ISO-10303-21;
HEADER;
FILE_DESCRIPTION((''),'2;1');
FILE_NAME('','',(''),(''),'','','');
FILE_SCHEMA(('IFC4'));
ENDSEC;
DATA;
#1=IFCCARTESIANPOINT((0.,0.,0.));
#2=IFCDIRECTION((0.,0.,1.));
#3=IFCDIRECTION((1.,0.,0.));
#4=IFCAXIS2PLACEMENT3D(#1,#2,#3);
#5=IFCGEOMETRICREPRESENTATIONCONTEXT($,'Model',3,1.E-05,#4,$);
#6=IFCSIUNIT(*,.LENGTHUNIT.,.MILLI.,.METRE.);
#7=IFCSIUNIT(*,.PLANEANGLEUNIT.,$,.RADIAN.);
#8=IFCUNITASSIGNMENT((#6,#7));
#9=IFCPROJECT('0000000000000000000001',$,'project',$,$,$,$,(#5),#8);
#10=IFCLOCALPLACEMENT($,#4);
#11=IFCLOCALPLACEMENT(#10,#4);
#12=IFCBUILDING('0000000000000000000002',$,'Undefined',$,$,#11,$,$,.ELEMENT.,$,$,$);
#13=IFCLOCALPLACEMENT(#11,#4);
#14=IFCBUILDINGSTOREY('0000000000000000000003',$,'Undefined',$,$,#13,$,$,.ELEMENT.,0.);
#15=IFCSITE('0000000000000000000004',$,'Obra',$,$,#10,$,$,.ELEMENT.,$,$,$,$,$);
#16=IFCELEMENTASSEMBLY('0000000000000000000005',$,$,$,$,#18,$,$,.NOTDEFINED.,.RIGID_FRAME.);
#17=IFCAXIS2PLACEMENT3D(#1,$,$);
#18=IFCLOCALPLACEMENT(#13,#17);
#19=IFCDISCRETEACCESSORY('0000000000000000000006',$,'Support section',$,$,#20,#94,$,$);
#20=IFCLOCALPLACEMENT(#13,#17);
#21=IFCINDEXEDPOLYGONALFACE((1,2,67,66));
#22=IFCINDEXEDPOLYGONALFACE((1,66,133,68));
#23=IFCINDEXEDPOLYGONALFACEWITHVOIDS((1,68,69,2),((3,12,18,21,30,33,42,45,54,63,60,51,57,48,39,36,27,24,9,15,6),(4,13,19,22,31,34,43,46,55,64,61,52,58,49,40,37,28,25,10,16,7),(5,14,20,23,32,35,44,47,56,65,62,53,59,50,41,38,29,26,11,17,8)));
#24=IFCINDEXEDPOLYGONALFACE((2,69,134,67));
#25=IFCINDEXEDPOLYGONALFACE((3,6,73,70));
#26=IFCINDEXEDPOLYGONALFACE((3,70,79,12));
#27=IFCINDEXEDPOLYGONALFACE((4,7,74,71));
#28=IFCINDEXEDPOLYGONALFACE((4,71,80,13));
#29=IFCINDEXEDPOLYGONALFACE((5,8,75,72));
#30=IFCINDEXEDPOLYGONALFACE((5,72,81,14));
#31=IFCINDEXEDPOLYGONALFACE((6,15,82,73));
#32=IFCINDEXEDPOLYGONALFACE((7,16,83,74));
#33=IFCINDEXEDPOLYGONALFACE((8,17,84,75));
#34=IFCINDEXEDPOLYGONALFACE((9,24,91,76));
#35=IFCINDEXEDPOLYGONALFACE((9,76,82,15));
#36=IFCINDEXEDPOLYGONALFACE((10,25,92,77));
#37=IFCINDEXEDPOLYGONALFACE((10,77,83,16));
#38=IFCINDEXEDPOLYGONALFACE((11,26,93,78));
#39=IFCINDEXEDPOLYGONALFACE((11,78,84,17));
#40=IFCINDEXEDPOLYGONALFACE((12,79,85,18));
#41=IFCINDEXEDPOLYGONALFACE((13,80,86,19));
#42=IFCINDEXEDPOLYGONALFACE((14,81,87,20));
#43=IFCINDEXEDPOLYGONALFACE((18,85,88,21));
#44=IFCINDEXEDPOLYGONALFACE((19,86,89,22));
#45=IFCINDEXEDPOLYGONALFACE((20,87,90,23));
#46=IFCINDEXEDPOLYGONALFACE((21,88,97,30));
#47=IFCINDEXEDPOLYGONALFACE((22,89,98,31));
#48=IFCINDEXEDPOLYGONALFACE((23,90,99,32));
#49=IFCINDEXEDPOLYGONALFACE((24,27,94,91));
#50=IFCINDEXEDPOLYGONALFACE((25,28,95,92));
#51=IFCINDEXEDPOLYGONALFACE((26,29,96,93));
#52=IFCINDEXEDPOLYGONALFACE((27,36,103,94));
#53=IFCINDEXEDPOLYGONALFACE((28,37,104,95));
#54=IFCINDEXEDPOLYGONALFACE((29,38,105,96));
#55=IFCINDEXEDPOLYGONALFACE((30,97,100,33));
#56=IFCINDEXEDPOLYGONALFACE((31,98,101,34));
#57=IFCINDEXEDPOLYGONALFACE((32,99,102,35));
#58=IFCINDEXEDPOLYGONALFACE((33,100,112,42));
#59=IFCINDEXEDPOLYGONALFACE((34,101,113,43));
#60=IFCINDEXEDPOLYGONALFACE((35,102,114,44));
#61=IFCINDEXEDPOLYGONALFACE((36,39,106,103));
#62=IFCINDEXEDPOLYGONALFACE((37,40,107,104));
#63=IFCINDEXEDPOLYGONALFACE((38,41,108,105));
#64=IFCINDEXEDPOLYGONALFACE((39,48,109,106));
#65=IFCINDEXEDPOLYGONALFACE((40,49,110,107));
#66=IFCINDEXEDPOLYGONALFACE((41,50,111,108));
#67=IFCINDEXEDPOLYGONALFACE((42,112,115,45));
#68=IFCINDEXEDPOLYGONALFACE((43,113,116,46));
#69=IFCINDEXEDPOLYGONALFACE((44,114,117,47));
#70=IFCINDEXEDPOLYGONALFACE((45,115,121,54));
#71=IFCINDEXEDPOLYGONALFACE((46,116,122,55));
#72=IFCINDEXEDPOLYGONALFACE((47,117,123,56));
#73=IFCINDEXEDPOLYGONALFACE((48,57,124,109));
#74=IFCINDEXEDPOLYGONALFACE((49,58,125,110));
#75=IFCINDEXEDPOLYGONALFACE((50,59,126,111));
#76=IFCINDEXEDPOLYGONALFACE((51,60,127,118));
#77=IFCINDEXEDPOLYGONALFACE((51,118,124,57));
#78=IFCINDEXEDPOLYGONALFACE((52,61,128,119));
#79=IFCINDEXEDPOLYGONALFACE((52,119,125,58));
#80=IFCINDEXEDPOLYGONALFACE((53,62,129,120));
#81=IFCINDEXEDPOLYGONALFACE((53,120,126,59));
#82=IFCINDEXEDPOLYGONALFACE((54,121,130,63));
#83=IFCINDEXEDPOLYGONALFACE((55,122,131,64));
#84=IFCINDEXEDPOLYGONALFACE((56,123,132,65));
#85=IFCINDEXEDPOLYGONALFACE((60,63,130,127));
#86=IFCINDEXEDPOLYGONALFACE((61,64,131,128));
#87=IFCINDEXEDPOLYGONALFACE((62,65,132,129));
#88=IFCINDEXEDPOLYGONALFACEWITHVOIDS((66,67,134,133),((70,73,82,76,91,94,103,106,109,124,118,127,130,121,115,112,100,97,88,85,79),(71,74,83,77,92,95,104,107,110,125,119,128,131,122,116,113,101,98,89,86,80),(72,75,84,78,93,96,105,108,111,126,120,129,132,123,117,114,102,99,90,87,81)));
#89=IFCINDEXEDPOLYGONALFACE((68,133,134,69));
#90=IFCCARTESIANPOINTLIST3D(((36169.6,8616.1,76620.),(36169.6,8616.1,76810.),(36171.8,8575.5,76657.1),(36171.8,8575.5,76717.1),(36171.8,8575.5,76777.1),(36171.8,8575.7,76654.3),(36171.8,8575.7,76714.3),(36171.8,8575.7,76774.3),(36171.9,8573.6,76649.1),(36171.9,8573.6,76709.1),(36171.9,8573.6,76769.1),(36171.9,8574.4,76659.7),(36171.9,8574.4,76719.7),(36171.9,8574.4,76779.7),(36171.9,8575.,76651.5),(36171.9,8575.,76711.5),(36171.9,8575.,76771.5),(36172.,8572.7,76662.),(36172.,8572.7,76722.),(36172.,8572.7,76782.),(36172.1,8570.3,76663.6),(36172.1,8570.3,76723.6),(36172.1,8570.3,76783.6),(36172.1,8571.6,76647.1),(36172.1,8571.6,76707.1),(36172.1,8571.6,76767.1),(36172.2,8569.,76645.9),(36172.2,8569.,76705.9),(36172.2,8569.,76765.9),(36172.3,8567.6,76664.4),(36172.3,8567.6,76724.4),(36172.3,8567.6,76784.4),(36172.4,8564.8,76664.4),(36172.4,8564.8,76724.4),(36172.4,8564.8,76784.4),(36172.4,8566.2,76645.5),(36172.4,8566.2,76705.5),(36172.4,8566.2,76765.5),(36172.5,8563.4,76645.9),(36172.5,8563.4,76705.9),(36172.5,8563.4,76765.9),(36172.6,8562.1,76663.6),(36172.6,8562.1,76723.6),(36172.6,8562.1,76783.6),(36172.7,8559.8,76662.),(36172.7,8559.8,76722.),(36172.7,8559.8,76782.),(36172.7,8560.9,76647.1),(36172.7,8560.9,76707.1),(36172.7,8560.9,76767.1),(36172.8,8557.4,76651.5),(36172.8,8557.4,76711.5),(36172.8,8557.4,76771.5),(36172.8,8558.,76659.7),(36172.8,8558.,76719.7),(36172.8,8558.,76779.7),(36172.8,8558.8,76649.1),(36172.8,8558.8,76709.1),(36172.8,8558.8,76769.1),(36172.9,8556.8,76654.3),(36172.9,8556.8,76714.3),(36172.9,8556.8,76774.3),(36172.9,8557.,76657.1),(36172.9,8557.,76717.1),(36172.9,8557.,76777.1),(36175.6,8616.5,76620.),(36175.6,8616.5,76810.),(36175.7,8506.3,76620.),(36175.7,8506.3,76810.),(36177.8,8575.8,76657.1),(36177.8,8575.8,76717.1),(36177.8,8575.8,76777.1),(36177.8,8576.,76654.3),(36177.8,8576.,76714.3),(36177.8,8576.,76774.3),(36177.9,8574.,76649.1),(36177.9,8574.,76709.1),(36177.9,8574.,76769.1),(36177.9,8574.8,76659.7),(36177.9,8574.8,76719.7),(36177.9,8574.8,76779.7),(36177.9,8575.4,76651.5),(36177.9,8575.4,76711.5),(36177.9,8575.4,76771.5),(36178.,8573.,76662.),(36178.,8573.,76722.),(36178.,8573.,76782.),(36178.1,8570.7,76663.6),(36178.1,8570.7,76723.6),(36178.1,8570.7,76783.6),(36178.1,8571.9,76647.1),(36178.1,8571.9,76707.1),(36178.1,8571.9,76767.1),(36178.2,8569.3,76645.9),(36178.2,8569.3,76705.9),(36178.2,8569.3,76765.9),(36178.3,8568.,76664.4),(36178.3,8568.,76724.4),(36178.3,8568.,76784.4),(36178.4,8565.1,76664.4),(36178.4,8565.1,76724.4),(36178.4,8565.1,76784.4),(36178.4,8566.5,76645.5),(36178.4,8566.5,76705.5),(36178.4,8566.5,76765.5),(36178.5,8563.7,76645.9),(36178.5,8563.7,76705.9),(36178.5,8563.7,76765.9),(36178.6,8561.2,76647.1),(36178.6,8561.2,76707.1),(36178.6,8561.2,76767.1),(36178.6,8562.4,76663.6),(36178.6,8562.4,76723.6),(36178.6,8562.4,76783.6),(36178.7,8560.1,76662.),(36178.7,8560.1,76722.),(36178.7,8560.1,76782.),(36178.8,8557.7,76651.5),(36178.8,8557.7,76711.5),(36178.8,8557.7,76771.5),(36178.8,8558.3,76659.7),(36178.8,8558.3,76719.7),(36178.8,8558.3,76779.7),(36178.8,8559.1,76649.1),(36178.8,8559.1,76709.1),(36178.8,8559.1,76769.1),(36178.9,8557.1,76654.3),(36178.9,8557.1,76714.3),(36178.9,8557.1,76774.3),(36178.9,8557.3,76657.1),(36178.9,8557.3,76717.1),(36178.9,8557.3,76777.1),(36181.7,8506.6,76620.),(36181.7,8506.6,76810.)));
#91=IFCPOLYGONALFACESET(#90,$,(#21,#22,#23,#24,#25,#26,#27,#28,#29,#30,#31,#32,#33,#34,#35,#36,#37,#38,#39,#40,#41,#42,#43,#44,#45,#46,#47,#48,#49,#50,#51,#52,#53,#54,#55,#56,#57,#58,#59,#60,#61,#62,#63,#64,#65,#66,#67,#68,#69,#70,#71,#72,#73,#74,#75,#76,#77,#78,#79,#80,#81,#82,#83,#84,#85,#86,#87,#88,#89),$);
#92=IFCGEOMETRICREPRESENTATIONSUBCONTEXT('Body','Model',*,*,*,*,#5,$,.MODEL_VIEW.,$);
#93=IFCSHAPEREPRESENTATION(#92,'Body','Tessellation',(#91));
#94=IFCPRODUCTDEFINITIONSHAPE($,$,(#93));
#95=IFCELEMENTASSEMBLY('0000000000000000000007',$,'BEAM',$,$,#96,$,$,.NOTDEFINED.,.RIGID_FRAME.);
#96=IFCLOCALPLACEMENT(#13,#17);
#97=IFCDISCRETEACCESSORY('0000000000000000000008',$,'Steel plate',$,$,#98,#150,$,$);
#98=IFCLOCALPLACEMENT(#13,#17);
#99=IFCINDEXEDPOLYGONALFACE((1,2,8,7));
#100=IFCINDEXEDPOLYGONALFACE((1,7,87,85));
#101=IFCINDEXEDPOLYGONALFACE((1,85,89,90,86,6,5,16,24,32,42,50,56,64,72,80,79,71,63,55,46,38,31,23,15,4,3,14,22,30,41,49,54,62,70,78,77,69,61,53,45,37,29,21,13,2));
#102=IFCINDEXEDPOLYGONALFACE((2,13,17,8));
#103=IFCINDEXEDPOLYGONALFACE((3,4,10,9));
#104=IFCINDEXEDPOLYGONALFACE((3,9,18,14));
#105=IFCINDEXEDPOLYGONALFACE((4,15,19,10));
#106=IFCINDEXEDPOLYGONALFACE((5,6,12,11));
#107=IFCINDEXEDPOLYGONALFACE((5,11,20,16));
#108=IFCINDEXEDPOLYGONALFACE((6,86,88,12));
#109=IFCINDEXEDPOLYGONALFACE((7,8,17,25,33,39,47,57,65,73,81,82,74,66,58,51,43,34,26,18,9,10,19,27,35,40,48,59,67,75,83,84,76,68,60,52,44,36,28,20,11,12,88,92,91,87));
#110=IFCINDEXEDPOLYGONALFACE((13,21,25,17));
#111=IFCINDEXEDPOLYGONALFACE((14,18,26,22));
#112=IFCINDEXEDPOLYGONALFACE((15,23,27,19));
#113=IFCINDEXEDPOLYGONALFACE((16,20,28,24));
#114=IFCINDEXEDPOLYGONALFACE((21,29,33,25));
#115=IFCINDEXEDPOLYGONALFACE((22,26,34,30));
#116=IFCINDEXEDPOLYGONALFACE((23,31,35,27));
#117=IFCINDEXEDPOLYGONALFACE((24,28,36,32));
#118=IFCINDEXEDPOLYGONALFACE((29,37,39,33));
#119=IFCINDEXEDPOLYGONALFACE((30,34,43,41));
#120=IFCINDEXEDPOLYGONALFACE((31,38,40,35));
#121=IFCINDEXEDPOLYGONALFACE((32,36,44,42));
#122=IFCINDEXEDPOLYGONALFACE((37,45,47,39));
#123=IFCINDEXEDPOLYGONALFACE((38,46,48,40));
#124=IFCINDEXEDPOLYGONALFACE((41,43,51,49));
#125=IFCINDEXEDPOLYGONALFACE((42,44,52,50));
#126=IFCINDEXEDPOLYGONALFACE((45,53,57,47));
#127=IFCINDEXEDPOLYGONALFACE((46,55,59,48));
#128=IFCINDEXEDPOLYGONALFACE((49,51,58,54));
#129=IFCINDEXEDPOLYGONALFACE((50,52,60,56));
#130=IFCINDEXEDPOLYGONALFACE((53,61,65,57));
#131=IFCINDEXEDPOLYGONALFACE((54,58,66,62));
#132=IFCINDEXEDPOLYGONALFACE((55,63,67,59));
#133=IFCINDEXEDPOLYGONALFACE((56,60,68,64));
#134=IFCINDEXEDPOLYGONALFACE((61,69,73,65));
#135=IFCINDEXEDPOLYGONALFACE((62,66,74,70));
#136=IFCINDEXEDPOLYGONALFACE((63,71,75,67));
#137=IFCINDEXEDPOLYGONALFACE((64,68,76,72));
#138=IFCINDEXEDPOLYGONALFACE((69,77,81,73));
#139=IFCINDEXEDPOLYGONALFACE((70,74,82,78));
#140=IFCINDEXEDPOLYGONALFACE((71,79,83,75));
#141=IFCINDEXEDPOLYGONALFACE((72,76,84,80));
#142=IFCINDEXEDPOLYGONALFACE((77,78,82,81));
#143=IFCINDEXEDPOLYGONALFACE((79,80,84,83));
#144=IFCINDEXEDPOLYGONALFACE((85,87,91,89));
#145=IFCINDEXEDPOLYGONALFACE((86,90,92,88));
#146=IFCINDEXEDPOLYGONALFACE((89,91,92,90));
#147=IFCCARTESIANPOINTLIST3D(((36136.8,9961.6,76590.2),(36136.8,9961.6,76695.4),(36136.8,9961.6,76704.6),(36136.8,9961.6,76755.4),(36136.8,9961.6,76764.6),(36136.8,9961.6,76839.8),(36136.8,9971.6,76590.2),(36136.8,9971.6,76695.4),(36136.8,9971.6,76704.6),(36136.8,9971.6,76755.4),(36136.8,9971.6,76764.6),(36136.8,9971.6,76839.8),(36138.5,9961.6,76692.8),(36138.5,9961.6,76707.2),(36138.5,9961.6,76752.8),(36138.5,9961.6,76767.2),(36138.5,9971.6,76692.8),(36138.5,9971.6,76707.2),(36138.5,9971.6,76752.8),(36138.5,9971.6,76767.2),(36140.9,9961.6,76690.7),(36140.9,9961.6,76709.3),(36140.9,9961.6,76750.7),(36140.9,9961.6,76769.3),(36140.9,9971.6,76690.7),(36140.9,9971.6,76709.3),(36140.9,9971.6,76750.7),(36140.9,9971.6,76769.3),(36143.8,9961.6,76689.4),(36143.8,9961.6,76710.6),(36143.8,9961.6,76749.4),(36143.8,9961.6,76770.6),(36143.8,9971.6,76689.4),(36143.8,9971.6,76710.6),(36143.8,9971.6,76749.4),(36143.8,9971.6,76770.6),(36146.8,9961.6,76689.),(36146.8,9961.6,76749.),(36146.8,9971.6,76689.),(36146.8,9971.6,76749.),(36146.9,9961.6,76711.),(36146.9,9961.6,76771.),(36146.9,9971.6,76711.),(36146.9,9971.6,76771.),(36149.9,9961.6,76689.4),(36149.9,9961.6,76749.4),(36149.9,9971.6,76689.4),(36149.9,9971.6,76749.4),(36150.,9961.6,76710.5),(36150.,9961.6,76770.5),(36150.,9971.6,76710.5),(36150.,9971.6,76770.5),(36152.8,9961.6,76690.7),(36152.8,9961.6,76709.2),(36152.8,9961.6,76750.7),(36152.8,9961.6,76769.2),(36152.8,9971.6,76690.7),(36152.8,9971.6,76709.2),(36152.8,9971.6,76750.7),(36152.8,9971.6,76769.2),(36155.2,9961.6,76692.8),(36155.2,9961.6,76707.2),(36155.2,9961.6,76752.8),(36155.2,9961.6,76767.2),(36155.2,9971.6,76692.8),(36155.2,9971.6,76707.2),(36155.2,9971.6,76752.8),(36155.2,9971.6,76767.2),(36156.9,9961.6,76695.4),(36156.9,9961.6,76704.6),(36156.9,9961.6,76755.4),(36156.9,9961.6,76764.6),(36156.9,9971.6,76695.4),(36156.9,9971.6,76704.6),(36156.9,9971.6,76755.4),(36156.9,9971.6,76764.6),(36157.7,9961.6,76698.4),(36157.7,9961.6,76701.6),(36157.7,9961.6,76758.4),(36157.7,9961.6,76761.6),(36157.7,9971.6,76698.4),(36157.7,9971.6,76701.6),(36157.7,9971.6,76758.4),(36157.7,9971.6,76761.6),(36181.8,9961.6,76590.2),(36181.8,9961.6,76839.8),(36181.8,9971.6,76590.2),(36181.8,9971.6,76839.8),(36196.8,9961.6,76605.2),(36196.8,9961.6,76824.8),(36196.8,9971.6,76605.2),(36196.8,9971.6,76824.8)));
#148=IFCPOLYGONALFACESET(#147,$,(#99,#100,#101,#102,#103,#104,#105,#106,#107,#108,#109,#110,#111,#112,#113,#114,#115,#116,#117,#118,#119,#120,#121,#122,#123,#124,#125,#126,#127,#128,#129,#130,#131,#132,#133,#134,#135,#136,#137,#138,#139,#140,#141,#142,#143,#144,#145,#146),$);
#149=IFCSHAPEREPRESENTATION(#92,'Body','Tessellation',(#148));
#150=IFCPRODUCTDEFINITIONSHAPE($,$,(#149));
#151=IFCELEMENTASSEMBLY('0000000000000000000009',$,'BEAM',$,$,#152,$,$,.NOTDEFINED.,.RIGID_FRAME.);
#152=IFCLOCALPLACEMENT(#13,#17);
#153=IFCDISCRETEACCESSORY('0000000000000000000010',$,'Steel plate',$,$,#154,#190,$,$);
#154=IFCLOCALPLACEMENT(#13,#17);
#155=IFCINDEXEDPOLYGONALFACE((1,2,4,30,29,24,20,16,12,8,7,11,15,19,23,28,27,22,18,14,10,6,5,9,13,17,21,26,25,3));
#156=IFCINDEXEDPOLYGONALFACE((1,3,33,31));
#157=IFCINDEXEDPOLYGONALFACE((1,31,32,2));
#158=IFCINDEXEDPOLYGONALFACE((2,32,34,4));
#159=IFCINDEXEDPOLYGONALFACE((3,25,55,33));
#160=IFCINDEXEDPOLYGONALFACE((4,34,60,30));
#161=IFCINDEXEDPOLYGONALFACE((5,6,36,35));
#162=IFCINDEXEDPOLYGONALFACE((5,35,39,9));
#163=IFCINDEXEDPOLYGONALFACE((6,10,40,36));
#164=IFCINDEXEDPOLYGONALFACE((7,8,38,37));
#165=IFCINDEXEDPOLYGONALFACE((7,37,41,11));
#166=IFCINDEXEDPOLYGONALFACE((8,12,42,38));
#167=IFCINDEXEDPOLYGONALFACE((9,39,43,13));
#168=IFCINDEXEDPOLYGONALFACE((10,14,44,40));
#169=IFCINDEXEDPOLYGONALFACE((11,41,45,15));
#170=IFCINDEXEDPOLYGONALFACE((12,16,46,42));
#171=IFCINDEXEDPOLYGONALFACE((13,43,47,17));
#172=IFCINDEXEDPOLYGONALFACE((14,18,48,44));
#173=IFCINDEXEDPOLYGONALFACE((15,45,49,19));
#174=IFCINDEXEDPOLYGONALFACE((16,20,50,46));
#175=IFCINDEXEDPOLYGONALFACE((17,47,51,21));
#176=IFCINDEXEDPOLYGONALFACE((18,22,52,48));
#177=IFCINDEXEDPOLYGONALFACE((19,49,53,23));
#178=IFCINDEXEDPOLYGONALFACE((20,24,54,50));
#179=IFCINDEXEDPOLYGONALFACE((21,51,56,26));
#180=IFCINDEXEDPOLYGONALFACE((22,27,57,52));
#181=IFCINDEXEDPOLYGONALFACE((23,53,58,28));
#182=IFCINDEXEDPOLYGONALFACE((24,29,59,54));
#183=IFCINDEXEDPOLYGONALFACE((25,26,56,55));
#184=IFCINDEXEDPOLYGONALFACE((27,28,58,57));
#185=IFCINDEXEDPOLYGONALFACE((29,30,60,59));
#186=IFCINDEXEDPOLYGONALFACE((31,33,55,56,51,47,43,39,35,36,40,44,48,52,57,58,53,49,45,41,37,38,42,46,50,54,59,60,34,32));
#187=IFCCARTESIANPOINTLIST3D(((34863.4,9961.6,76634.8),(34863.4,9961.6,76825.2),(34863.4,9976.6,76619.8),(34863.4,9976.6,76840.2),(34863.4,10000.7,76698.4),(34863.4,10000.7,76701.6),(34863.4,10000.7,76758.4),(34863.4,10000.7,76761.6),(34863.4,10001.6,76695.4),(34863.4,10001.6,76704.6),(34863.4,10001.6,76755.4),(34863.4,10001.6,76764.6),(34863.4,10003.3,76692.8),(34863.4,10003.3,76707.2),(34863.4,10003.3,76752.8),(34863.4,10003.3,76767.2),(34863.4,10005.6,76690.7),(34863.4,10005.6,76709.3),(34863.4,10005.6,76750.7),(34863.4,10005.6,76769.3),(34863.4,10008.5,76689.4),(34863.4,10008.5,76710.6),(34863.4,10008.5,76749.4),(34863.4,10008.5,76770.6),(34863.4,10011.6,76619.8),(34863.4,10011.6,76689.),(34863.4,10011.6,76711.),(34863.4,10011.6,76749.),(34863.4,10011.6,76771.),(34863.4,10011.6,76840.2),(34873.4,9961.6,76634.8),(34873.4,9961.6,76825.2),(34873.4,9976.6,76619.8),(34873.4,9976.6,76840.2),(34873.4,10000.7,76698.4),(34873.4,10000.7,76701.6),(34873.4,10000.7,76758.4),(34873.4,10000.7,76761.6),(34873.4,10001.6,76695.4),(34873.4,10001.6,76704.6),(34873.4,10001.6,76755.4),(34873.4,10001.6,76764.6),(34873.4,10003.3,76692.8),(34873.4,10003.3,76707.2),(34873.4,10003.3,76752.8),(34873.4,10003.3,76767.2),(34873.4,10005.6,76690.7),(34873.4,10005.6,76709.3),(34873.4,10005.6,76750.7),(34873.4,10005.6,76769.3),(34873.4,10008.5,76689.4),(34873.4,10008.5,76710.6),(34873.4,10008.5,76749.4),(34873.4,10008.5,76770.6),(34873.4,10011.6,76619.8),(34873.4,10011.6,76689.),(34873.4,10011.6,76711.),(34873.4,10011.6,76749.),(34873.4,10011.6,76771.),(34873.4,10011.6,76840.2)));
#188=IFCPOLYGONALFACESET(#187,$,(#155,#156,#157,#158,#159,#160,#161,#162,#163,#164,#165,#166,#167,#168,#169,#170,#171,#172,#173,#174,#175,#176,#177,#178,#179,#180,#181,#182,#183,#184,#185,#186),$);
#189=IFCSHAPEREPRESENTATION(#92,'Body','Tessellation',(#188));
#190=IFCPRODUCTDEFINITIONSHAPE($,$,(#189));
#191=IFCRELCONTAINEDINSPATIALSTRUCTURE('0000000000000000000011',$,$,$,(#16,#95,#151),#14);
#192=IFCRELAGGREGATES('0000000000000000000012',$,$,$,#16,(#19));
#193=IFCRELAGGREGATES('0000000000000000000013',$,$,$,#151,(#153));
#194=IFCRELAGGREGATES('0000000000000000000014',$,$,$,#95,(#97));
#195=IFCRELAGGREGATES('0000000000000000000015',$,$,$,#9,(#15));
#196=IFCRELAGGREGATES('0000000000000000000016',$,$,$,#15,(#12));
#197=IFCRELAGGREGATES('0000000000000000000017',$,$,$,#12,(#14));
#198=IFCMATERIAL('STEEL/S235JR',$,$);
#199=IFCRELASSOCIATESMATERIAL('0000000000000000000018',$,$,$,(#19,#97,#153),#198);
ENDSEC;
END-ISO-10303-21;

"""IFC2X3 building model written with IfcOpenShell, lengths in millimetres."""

from ifc_helpers import new_model, si_unit, frame, origin_with_axes, origin_2d_with_axis, place, context, subcontext, project, spatial, polyline, rectangle, circle, outline, extrude, source, transform, mapped, material, element, aggregate, save


model = new_model("IFC2X3")

# Units and contexts
model_context = context("Model", 3, precision=1e-05, world=origin_with_axes())
body_context = subcontext(model_context, "Body", "Model", "MODEL_VIEW")
ifc_project = project(units=[si_unit("LENGTHUNIT", "METRE", prefix="MILLI"), si_unit("PLANEANGLEUNIT", "RADIAN")], contexts=[model_context])

# Site, building, storey
site_placement = place(None, origin_with_axes())
site = spatial("IfcSite", under=ifc_project, at=site_placement, Name="Obra", CompositionType="ELEMENT")
building_placement = place(site_placement, origin_with_axes())
building = spatial("IfcBuilding", under=site, at=building_placement, Name="Undefined", CompositionType="ELEMENT")
storey_placement = place(building_placement, origin_with_axes())
storey = spatial("IfcBuildingStorey", under=building, at=storey_placement, Name="Undefined", CompositionType="ELEMENT", Elevation=0.0)

# Element assembly
ifc_material = material(Name="STEEL/S235JR")
assembly_1_placement = place(storey_placement, origin_with_axes())
assembly_1 = element("IfcElementAssembly", 1, at=assembly_1_placement, inside=storey, AssemblyPlace="NOTDEFINED", PredefinedType="RIGID_FRAME")

# Discrete accessory, opening
shared_shape_1 = source(origin_with_axes(), body_context, "Body", "SweptSolid", [
    extrude(circle(Radius=9.5, at=origin_2d_with_axis()), frame((0.0, -9.2, 0.0), z_axis=(0.0, 1.0, 0.0), x_axis=(1.0, 0.0, 0.0)), (0.0, 0.0, 1.0), 6.2),
])
discrete_accessory_1_placement = place(assembly_1_placement, frame((36175.6, 8561.4, 76620.0), z_axis=(0.0, 0.0, 1.0), x_axis=(0.055152, -0.998478, 0.0)))
discrete_accessory_1 = element("IfcDiscreteAccessory", 2, at=discrete_accessory_1_placement, material=ifc_material, Name="Support section", context=body_context, shape_type="SweptSolid", body=[
    extrude(rectangle(XDim=6.0, YDim=110.0, at=origin_2d_with_axis()), frame((0.0, 0.0, 190.0), z_axis=(0.0, 0.0, -1.0), x_axis=(0.0, 1.0, 0.0)), (0.0, 0.0, 1.0), 190.0),
])
opening_1_placement = place(assembly_1_placement, frame((36172.0, 8516.1, 76835.0), z_axis=(-0.055152, 0.998478, 0.0), x_axis=(0.0, 0.0, -1.0)))
element("IfcOpeningElement", 3, at=opening_1_placement, cuts=discrete_accessory_1, ObjectType="Opening", context=body_context, shape_type="MappedRepresentation", body=[
    mapped(shared_shape_1, transform((60.0, 0.0, 50.0))),
    mapped(shared_shape_1, transform((120.0, 0.0, 50.0))),
    mapped(shared_shape_1, transform((180.0, 0.0, 50.0))),
])
aggregate(assembly_1, [discrete_accessory_1])

# Element assemblies, discrete accessories, openings
assembly_2_placement = place(storey_placement, origin_with_axes())
assembly_2 = element("IfcElementAssembly", 4, at=assembly_2_placement, inside=storey, Name="BEAM", AssemblyPlace="NOTDEFINED", PredefinedType="RIGID_FRAME")
discrete_accessory_2_placement = place(assembly_2_placement, frame((36136.8, 9966.6, 76590.2), z_axis=(0.0, -1.0, 0.0), x_axis=(1.0, 0.0, 0.0)))
discrete_accessory_2 = element("IfcDiscreteAccessory", 5, at=discrete_accessory_2_placement, material=ifc_material, Name="Steel plate", context=body_context, shape_type="SweptSolid", body=[
    extrude(outline(polyline([(0.0, 0.0), (45.0, 0.0), (60.0, 15.0), (60.0, 234.6), (45.0, 249.6), (0.0, 249.6), (0.0, 0.0)])), frame((0.0, 0.0, -5.0), z_axis=(0.0, 0.0, 1.0), x_axis=(1.0, 0.0, 0.0)), (0.0, 0.0, 1.0), 10.0),
])
shared_shape_2 = source(origin_with_axes(), body_context, "Body", "SweptSolid", [
    extrude(circle(Radius=11.0, at=origin_2d_with_axis()), frame((0.0, -13.2, 0.0), z_axis=(0.0, 1.0, 0.0), x_axis=(1.0, 0.0, 0.0)), (0.0, 0.0, 1.0), 10.2),
])
opening_2_placement = place(assembly_2_placement, frame((36186.8, 9958.5, 76850.0), z_axis=(-1.0, 0.0, 0.0), x_axis=(0.0, 0.0, -1.0)))
element("IfcOpeningElement", 6, at=opening_2_placement, cuts=discrete_accessory_2, ObjectType="Opening", context=body_context, shape_type="MappedRepresentation", body=[
    mapped(shared_shape_2, transform((90.0, 0.0, 40.0))),
    mapped(shared_shape_2, transform((150.0, 0.0, 40.0))),
])
assembly_3_placement = place(storey_placement, origin_with_axes())
assembly_3 = element("IfcElementAssembly", 7, at=assembly_3_placement, inside=storey, Name="BEAM", AssemblyPlace="NOTDEFINED", PredefinedType="RIGID_FRAME")
discrete_accessory_3_placement = place(assembly_3_placement, frame((34868.4, 10011.6, 76619.8), z_axis=(-1.0, 0.0, 0.0), x_axis=(0.0, -1.0, 0.0)))
discrete_accessory_3 = element("IfcDiscreteAccessory", 8, at=discrete_accessory_3_placement, material=ifc_material, Name="Steel plate", context=body_context, shape_type="SweptSolid", body=[
    extrude(outline(polyline([(0.0, 0.0), (35.0, 0.0), (50.0, 15.0), (50.0, 205.4), (35.0, 220.4), (0.0, 220.4), (0.0, 0.0)])), frame((0.0, 0.0, -5.0), z_axis=(0.0, 0.0, 1.0), x_axis=(1.0, 0.0, 0.0)), (0.0, 0.0, 1.0), 10.0),
])
opening_3_placement = place(assembly_3_placement, frame((34860.3, 9971.6, 76850.0), z_axis=(0.0, 1.0, 0.0), x_axis=(0.0, 0.0, -1.0)))
element("IfcOpeningElement", 9, at=opening_3_placement, cuts=discrete_accessory_3, ObjectType="Opening", context=body_context, shape_type="MappedRepresentation", body=[
    mapped(shared_shape_2, transform((90.0, 0.0, 40.0))),
    mapped(shared_shape_2, transform((150.0, 0.0, 40.0))),
])
aggregate(assembly_3, [discrete_accessory_3])

aggregate(assembly_2, [discrete_accessory_2])

save(model, "model.ifc")
